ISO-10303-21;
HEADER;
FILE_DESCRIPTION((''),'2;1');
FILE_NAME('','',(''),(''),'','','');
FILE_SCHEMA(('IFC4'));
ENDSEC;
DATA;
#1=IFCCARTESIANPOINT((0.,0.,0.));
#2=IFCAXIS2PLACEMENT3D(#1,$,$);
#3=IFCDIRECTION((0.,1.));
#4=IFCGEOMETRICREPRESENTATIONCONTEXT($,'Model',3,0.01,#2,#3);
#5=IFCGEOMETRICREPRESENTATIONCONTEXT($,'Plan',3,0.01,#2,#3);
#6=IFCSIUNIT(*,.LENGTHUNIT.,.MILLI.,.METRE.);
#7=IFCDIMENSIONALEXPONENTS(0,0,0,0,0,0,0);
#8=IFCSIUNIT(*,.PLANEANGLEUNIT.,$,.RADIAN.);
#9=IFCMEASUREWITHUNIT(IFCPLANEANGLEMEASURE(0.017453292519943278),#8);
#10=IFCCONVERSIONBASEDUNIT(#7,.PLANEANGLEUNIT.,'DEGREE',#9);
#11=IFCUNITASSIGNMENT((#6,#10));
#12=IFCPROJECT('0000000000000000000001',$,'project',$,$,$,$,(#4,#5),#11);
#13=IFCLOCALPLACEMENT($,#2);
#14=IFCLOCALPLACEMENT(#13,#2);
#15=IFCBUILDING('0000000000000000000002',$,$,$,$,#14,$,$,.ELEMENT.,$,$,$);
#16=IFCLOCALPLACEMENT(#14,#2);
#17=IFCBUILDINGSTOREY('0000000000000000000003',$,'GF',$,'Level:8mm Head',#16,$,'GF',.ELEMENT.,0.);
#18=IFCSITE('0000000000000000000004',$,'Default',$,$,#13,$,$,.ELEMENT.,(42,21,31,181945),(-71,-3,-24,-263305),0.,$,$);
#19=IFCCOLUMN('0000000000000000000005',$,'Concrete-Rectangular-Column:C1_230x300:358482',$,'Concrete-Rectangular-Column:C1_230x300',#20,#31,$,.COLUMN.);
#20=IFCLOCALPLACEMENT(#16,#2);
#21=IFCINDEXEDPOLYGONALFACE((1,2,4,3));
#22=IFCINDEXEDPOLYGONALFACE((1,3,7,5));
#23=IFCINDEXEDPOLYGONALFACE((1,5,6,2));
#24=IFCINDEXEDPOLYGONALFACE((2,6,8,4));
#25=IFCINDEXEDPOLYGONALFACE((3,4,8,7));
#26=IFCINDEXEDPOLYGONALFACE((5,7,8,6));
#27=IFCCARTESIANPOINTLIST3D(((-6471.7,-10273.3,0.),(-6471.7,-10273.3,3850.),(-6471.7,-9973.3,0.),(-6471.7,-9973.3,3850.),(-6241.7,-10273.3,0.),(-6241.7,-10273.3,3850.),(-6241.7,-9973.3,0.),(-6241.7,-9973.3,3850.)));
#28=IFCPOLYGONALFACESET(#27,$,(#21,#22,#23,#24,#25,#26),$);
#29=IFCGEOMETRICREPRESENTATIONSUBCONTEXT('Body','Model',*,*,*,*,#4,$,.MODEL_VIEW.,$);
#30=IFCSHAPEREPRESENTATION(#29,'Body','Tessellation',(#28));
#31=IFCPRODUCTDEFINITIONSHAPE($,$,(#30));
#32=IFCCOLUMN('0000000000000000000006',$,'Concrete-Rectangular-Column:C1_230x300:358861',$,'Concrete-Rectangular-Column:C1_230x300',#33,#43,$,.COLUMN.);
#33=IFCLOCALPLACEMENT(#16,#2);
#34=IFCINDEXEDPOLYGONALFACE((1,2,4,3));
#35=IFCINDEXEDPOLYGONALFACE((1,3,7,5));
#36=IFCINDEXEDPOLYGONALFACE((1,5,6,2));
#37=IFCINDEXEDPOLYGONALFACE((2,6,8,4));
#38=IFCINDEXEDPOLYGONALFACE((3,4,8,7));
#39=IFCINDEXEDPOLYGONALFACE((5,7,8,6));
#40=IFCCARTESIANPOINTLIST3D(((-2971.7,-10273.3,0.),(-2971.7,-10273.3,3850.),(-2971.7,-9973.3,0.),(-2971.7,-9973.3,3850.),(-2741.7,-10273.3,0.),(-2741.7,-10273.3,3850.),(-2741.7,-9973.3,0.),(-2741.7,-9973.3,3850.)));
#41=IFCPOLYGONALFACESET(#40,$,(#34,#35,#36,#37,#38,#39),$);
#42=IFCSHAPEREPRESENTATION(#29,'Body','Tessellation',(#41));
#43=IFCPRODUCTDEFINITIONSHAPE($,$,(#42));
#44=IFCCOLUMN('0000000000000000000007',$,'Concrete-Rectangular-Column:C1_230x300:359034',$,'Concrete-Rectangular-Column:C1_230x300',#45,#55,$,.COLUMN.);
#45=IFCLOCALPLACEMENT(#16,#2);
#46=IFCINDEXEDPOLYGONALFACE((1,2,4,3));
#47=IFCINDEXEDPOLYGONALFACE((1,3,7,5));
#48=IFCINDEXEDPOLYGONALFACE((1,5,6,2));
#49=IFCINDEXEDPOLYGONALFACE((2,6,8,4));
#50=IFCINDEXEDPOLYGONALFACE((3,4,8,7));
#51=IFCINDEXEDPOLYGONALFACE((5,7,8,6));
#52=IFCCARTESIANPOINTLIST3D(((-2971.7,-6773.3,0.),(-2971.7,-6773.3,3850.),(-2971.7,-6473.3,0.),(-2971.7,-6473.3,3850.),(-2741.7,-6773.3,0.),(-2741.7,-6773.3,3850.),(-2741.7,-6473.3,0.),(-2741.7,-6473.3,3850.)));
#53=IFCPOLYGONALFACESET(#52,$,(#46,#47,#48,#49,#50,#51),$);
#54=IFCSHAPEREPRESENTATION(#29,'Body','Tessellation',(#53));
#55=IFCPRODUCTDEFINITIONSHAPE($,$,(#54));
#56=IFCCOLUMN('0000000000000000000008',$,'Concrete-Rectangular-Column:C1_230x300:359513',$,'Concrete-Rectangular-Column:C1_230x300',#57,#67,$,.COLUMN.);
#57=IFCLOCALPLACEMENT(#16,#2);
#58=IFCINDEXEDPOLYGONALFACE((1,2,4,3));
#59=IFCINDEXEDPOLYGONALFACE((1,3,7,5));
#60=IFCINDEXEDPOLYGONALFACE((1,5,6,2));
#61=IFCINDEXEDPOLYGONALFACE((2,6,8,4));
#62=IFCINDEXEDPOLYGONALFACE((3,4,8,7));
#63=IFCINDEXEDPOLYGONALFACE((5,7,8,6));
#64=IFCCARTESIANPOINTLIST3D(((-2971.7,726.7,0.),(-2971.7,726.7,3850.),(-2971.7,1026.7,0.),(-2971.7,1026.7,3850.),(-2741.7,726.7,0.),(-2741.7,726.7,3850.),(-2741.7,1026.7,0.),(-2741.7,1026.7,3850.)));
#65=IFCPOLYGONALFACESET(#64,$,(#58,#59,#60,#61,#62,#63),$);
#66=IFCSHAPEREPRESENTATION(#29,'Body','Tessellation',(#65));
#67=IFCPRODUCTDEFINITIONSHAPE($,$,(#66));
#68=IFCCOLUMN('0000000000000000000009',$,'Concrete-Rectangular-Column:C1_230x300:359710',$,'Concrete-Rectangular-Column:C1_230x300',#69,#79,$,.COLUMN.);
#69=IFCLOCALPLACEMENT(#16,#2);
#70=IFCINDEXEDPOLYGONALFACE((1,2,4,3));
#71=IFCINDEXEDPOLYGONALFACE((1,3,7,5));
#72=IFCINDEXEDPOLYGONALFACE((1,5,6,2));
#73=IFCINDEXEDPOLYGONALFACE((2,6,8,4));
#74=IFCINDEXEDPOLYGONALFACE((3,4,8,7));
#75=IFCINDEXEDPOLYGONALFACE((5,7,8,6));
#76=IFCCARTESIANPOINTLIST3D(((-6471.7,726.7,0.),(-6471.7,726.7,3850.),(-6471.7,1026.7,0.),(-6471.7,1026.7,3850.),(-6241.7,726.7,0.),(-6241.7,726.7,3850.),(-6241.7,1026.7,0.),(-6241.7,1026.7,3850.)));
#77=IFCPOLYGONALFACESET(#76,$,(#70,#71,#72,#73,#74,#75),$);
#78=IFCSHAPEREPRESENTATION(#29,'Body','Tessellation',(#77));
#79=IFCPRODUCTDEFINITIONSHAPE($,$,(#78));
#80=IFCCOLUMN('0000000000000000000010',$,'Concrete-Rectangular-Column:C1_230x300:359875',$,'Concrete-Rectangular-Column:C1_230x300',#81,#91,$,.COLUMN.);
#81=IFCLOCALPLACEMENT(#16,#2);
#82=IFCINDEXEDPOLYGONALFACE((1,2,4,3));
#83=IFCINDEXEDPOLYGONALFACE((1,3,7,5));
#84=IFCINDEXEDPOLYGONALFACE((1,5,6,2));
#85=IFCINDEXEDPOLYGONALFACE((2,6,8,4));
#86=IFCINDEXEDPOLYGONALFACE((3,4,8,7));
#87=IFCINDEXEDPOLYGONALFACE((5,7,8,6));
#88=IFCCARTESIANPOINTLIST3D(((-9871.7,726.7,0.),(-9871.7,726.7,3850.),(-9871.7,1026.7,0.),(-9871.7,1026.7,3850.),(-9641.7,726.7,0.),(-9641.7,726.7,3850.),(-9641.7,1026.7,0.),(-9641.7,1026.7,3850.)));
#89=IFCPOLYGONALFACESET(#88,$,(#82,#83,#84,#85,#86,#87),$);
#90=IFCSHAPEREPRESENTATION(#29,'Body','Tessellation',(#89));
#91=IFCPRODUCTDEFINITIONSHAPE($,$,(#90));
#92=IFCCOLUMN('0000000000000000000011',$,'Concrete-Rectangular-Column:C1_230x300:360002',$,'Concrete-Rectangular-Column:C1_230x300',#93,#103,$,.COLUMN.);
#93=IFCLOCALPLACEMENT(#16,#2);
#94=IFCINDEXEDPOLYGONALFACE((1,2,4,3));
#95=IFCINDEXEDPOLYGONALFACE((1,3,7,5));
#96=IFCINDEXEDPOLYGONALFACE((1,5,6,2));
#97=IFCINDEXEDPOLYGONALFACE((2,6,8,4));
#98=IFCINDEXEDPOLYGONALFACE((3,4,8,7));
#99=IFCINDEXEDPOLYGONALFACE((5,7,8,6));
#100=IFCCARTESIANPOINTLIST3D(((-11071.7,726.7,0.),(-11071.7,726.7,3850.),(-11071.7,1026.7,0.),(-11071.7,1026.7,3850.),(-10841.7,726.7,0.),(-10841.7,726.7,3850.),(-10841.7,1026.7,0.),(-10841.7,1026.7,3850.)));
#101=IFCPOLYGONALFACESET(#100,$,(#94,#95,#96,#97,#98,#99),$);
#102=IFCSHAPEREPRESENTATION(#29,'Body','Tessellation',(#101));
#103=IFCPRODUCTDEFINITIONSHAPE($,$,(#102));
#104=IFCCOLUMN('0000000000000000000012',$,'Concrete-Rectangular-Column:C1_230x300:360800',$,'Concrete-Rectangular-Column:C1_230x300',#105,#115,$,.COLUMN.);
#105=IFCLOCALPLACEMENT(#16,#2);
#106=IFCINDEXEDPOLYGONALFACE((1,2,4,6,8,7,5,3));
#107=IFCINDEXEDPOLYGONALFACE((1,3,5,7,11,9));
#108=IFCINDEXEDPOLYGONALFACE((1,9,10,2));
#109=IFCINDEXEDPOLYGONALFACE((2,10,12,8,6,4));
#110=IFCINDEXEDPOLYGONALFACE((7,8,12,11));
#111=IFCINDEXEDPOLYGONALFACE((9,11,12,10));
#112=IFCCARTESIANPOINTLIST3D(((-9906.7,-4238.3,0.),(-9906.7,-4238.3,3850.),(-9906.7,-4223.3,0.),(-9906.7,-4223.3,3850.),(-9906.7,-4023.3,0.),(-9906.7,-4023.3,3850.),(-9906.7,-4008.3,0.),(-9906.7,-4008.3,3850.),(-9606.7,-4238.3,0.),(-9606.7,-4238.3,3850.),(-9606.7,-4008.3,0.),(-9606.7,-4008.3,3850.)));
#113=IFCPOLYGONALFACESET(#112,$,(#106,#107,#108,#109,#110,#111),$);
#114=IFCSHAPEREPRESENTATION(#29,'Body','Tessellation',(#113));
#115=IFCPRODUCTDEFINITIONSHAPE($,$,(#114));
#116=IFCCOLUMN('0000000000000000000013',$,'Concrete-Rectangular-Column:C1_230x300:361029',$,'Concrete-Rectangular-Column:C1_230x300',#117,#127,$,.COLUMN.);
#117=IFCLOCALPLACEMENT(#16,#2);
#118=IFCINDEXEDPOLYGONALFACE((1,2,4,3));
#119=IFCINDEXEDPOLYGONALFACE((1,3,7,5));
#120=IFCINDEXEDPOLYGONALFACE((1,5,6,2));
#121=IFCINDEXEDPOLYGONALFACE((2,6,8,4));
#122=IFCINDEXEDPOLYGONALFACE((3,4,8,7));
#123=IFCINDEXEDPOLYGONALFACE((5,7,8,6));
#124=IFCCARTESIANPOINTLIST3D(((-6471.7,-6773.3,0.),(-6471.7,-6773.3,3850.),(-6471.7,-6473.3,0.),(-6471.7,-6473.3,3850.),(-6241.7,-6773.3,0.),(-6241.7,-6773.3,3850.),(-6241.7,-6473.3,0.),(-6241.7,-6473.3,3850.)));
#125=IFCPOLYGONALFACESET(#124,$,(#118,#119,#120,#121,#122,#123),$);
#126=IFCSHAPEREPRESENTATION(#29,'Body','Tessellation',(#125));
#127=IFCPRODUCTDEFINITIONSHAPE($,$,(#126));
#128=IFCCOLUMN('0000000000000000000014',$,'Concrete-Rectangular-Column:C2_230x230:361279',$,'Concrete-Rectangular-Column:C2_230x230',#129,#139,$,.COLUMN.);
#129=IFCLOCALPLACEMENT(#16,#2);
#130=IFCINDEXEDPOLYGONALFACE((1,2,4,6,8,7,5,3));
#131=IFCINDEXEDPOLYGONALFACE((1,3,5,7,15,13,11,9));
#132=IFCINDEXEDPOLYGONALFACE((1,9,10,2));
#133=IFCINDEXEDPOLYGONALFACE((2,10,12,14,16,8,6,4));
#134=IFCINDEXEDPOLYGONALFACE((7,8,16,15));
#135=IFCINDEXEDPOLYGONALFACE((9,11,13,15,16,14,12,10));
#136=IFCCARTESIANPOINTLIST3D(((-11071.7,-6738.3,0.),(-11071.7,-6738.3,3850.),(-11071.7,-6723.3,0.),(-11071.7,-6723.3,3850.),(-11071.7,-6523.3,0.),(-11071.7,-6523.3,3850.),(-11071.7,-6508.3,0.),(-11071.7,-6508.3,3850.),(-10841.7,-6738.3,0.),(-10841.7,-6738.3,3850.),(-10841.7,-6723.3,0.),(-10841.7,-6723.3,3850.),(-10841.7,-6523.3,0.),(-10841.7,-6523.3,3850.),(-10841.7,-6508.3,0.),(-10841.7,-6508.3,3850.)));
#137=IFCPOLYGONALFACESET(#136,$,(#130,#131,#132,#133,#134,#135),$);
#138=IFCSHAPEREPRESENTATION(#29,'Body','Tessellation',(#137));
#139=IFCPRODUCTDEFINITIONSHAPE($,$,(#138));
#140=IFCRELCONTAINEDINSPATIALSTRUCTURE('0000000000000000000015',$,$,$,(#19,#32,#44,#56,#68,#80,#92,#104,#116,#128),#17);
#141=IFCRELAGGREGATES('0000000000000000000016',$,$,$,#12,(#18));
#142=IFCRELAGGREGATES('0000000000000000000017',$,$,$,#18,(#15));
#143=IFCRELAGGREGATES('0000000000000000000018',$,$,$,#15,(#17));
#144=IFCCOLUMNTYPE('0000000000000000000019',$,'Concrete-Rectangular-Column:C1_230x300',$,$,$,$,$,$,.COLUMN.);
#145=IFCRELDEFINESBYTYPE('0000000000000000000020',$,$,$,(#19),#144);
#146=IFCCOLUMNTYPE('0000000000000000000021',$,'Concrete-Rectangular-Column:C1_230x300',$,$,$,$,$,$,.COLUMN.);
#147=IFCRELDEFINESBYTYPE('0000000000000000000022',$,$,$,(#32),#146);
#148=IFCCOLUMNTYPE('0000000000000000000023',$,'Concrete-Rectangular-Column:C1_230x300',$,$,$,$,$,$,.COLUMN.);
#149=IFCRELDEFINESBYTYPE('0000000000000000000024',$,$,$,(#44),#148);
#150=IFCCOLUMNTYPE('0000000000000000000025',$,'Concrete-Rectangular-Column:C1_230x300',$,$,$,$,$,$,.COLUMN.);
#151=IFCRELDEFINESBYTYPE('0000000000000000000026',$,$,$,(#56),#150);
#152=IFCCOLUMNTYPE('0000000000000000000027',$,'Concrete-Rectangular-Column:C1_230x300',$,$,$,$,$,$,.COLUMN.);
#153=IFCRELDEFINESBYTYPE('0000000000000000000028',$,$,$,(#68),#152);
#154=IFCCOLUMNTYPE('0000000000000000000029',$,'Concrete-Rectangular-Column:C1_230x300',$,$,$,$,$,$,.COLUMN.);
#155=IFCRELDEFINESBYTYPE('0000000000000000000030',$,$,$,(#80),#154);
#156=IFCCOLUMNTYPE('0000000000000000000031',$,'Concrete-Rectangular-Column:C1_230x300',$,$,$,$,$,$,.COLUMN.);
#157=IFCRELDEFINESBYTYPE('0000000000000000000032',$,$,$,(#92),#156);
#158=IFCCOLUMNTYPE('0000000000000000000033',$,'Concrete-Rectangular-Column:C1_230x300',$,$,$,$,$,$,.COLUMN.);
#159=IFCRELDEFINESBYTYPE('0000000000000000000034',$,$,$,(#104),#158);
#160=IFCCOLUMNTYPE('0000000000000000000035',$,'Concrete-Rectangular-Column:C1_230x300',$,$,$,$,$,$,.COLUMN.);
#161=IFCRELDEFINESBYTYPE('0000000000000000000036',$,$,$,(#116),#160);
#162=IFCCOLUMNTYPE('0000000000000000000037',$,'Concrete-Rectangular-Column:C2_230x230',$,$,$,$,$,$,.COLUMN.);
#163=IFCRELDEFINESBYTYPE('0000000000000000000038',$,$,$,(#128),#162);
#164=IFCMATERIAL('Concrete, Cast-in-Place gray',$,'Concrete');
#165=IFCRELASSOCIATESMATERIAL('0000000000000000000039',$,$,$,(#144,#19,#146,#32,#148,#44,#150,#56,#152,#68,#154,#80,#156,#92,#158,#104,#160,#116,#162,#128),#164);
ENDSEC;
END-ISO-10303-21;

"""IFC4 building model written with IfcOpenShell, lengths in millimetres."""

from ifc_helpers import new_model, entity, si_unit, converted_unit, direction, frame, origin, place, context, subcontext, project, spatial, indexed_curve, outline, extrude, source, transform, mapped, material, type_object, type_shapes, element, save


model = new_model("IFC4")

# Units and contexts
model_context = context("Model", 3, precision=0.01, world=origin(), true_north=direction((0.0, 1.0)))
plan_context = context("Plan", 3, precision=0.01, world=origin(), true_north=direction((0.0, 1.0)))
body_context = subcontext(model_context, "Body", "Model", "MODEL_VIEW")
ifc_project = project(units=[si_unit("LENGTHUNIT", "METRE", prefix="MILLI"), converted_unit("PLANEANGLEUNIT", "DEGREE", entity("IfcPlaneAngleMeasure", 0.017453292519943278), si_unit("PLANEANGLEUNIT", "RADIAN"), dimensions=[0, 0, 0, 0, 0, 0, 0])], contexts=[model_context, plan_context])

# Site, building, storey
site_placement = place(None, origin())
site = spatial("IfcSite", under=ifc_project, at=site_placement, Name="Default", CompositionType="ELEMENT", RefLatitude=(42, 21, 31, 181945), RefLongitude=(-71, -3, -24, -263305), RefElevation=0.0)
building_placement = place(site_placement, origin())
building = spatial("IfcBuilding", under=site, at=building_placement, CompositionType="ELEMENT")
storey_placement = place(building_placement, origin())
storey = spatial("IfcBuildingStorey", under=building, at=storey_placement, Name="GF", ObjectType="Level:8mm Head", LongName="GF", CompositionType="ELEMENT", Elevation=0.0)

# Columns
ifc_material = material(Name="Concrete, Cast-in-Place gray", Category="Concrete")
column_type_1 = type_object("IfcColumnType", Name="Concrete-Rectangular-Column:C1_230x300", PredefinedType="COLUMN", material=ifc_material)
shared_shape_1 = source(origin(), body_context, "Body", "SweptSolid", [
    extrude(outline(indexed_curve([(-1925.0, -150.0), (1925.0, -150.0), (1925.0, 150.0), (-1925.0, 150.0), (-1925.0, -150.0)], self_intersect=False)), frame((-6471.7, -10123.3, 1925.0), z_axis=(1.0, 0.0, 0.0), x_axis=(0.0, 0.0, 1.0)), (0.0, 0.0, 1.0), 230.0),
])
type_shapes(column_type_1, [shared_shape_1])
column_1_placement = place(storey_placement, origin())
element("IfcColumn", 1, at=column_1_placement, inside=storey, type_object=column_type_1, material=ifc_material, Name="Concrete-Rectangular-Column:C1_230x300:358482", ObjectType="Concrete-Rectangular-Column:C1_230x300", PredefinedType="COLUMN", context=body_context, shape_type="MappedRepresentation", body=[
    mapped(shared_shape_1, transform((0.0, 0.0, 0.0), scale=1.0)),
])
column_type_2 = type_object("IfcColumnType", Name="Concrete-Rectangular-Column:C1_230x300", PredefinedType="COLUMN", material=ifc_material)
shared_shape_2 = source(origin(), body_context, "Body", "SweptSolid", [
    extrude(outline(indexed_curve([(-1925.0, -150.0), (1925.0, -150.0), (1925.0, 150.0), (-1925.0, 150.0), (-1925.0, -150.0)], self_intersect=False)), frame((-2971.7, -10123.3, 1925.0), z_axis=(1.0, 0.0, 0.0), x_axis=(0.0, 0.0, 1.0)), (0.0, 0.0, 1.0), 230.0),
])
type_shapes(column_type_2, [shared_shape_2])
column_2_placement = place(storey_placement, origin())
element("IfcColumn", 2, at=column_2_placement, inside=storey, type_object=column_type_2, material=ifc_material, Name="Concrete-Rectangular-Column:C1_230x300:358861", ObjectType="Concrete-Rectangular-Column:C1_230x300", PredefinedType="COLUMN", context=body_context, shape_type="MappedRepresentation", body=[
    mapped(shared_shape_2, transform((0.0, 0.0, 0.0), scale=1.0)),
])
column_type_3 = type_object("IfcColumnType", Name="Concrete-Rectangular-Column:C1_230x300", PredefinedType="COLUMN", material=ifc_material)
shared_shape_3 = source(origin(), body_context, "Body", "SweptSolid", [
    extrude(outline(indexed_curve([(-1925.0, -150.0), (1925.0, -150.0), (1925.0, 150.0), (-1925.0, 150.0), (-1925.0, -150.0)], self_intersect=False)), frame((-2971.7, -6623.3, 1925.0), z_axis=(1.0, 0.0, 0.0), x_axis=(0.0, 0.0, 1.0)), (0.0, 0.0, 1.0), 230.0),
])
type_shapes(column_type_3, [shared_shape_3])
column_3_placement = place(storey_placement, origin())
element("IfcColumn", 3, at=column_3_placement, inside=storey, type_object=column_type_3, material=ifc_material, Name="Concrete-Rectangular-Column:C1_230x300:359034", ObjectType="Concrete-Rectangular-Column:C1_230x300", PredefinedType="COLUMN", context=body_context, shape_type="MappedRepresentation", body=[
    mapped(shared_shape_3, transform((0.0, 0.0, 0.0), scale=1.0)),
])
column_type_4 = type_object("IfcColumnType", Name="Concrete-Rectangular-Column:C1_230x300", PredefinedType="COLUMN", material=ifc_material)
shared_shape_4 = source(origin(), body_context, "Body", "SweptSolid", [
    extrude(outline(indexed_curve([(-1925.0, -150.0), (1925.0, -150.0), (1925.0, 150.0), (-1925.0, 150.0), (-1925.0, -150.0)], self_intersect=False)), frame((-2971.7, 876.7, 1925.0), z_axis=(1.0, 0.0, 0.0), x_axis=(0.0, 0.0, 1.0)), (0.0, 0.0, 1.0), 230.0),
])
type_shapes(column_type_4, [shared_shape_4])
column_4_placement = place(storey_placement, origin())
element("IfcColumn", 4, at=column_4_placement, inside=storey, type_object=column_type_4, material=ifc_material, Name="Concrete-Rectangular-Column:C1_230x300:359513", ObjectType="Concrete-Rectangular-Column:C1_230x300", PredefinedType="COLUMN", context=body_context, shape_type="MappedRepresentation", body=[
    mapped(shared_shape_4, transform((0.0, 0.0, 0.0), scale=1.0)),
])
column_type_5 = type_object("IfcColumnType", Name="Concrete-Rectangular-Column:C1_230x300", PredefinedType="COLUMN", material=ifc_material)
shared_shape_5 = source(origin(), body_context, "Body", "SweptSolid", [
    extrude(outline(indexed_curve([(-1925.0, -150.0), (1925.0, -150.0), (1925.0, 150.0), (-1925.0, 150.0), (-1925.0, -150.0)], self_intersect=False)), frame((-6471.7, 876.7, 1925.0), z_axis=(1.0, 0.0, 0.0), x_axis=(0.0, 0.0, 1.0)), (0.0, 0.0, 1.0), 230.0),
])
type_shapes(column_type_5, [shared_shape_5])
column_5_placement = place(storey_placement, origin())
element("IfcColumn", 5, at=column_5_placement, inside=storey, type_object=column_type_5, material=ifc_material, Name="Concrete-Rectangular-Column:C1_230x300:359710", ObjectType="Concrete-Rectangular-Column:C1_230x300", PredefinedType="COLUMN", context=body_context, shape_type="MappedRepresentation", body=[
    mapped(shared_shape_5, transform((0.0, 0.0, 0.0), scale=1.0)),
])
column_type_6 = type_object("IfcColumnType", Name="Concrete-Rectangular-Column:C1_230x300", PredefinedType="COLUMN", material=ifc_material)
shared_shape_6 = source(origin(), body_context, "Body", "SweptSolid", [
    extrude(outline(indexed_curve([(-1925.0, -150.0), (1925.0, -150.0), (1925.0, 150.0), (-1925.0, 150.0), (-1925.0, -150.0)], self_intersect=False)), frame((-9871.7, 876.7, 1925.0), z_axis=(1.0, 0.0, 0.0), x_axis=(0.0, 0.0, 1.0)), (0.0, 0.0, 1.0), 230.0),
])
type_shapes(column_type_6, [shared_shape_6])
column_6_placement = place(storey_placement, origin())
element("IfcColumn", 6, at=column_6_placement, inside=storey, type_object=column_type_6, material=ifc_material, Name="Concrete-Rectangular-Column:C1_230x300:359875", ObjectType="Concrete-Rectangular-Column:C1_230x300", PredefinedType="COLUMN", context=body_context, shape_type="MappedRepresentation", body=[
    mapped(shared_shape_6, transform((0.0, 0.0, 0.0), scale=1.0)),
])
column_type_7 = type_object("IfcColumnType", Name="Concrete-Rectangular-Column:C1_230x300", PredefinedType="COLUMN", material=ifc_material)
shared_shape_7 = source(origin(), body_context, "Body", "SweptSolid", [
    extrude(outline(indexed_curve([(-1925.0, -150.0), (1925.0, -150.0), (1925.0, 150.0), (-1925.0, 150.0), (-1925.0, -150.0)], self_intersect=False)), frame((-11071.7, 876.7, 1925.0), z_axis=(1.0, 0.0, 0.0), x_axis=(0.0, 0.0, 1.0)), (0.0, 0.0, 1.0), 230.0),
])
type_shapes(column_type_7, [shared_shape_7])
column_7_placement = place(storey_placement, origin())
element("IfcColumn", 7, at=column_7_placement, inside=storey, type_object=column_type_7, material=ifc_material, Name="Concrete-Rectangular-Column:C1_230x300:360002", ObjectType="Concrete-Rectangular-Column:C1_230x300", PredefinedType="COLUMN", context=body_context, shape_type="MappedRepresentation", body=[
    mapped(shared_shape_7, transform((0.0, 0.0, 0.0), scale=1.0)),
])
column_type_8 = type_object("IfcColumnType", Name="Concrete-Rectangular-Column:C1_230x300", PredefinedType="COLUMN", material=ifc_material)
shared_shape_8 = source(origin(), body_context, "Body", "SweptSolid", [
    extrude(outline(indexed_curve([(-115.0, -200.0), (115.0, -200.0), (115.0, 100.0), (100.0, 100.0), (-100.0, 100.0), (-115.0, 100.0), (-115.0, -200.0)], self_intersect=False)), frame((-9806.7, -4123.3, 0.0), z_axis=(0.0, 0.0, 1.0), x_axis=(0.0, 1.0, 0.0)), (0.0, 0.0, 1.0), 3850.0),
])
type_shapes(column_type_8, [shared_shape_8])
column_8_placement = place(storey_placement, origin())
element("IfcColumn", 8, at=column_8_placement, inside=storey, type_object=column_type_8, material=ifc_material, Name="Concrete-Rectangular-Column:C1_230x300:360800", ObjectType="Concrete-Rectangular-Column:C1_230x300", PredefinedType="COLUMN", context=body_context, shape_type="MappedRepresentation", body=[
    mapped(shared_shape_8, transform((0.0, 0.0, 0.0), scale=1.0)),
])
column_type_9 = type_object("IfcColumnType", Name="Concrete-Rectangular-Column:C1_230x300", PredefinedType="COLUMN", material=ifc_material)
shared_shape_9 = source(origin(), body_context, "Body", "SweptSolid", [
    extrude(outline(indexed_curve([(-1925.0, -150.0), (1925.0, -150.0), (1925.0, 150.0), (-1925.0, 150.0), (-1925.0, -150.0)], self_intersect=False)), frame((-6471.7, -6623.3, 1925.0), z_axis=(1.0, 0.0, 0.0), x_axis=(0.0, 0.0, 1.0)), (0.0, 0.0, 1.0), 230.0),
])
type_shapes(column_type_9, [shared_shape_9])
column_9_placement = place(storey_placement, origin())
element("IfcColumn", 9, at=column_9_placement, inside=storey, type_object=column_type_9, material=ifc_material, Name="Concrete-Rectangular-Column:C1_230x300:361029", ObjectType="Concrete-Rectangular-Column:C1_230x300", PredefinedType="COLUMN", context=body_context, shape_type="MappedRepresentation", body=[
    mapped(shared_shape_9, transform((0.0, 0.0, 0.0), scale=1.0)),
])
column_type_10 = type_object("IfcColumnType", Name="Concrete-Rectangular-Column:C2_230x230", PredefinedType="COLUMN", material=ifc_material)
shared_shape_10 = source(origin(), body_context, "Body", "SweptSolid", [
    extrude(outline(indexed_curve([(-115.0, -115.0), (-100.0, -115.0), (100.0, -115.0), (115.0, -115.0), (115.0, 115.0), (100.0, 115.0), (-100.0, 115.0), (-115.0, 115.0), (-115.0, -115.0)], self_intersect=False)), frame((-10956.7, -6623.3, 0.0), z_axis=(0.0, 0.0, 1.0), x_axis=(0.0, -1.0, 0.0)), (0.0, 0.0, 1.0), 3850.0),
])
type_shapes(column_type_10, [shared_shape_10])
column_10_placement = place(storey_placement, origin())
element("IfcColumn", 10, at=column_10_placement, inside=storey, type_object=column_type_10, material=ifc_material, Name="Concrete-Rectangular-Column:C2_230x230:361279", ObjectType="Concrete-Rectangular-Column:C2_230x230", PredefinedType="COLUMN", context=body_context, shape_type="MappedRepresentation", body=[
    mapped(shared_shape_10, transform((0.0, 0.0, 0.0), scale=1.0)),
])

save(model, "model.ifc")
